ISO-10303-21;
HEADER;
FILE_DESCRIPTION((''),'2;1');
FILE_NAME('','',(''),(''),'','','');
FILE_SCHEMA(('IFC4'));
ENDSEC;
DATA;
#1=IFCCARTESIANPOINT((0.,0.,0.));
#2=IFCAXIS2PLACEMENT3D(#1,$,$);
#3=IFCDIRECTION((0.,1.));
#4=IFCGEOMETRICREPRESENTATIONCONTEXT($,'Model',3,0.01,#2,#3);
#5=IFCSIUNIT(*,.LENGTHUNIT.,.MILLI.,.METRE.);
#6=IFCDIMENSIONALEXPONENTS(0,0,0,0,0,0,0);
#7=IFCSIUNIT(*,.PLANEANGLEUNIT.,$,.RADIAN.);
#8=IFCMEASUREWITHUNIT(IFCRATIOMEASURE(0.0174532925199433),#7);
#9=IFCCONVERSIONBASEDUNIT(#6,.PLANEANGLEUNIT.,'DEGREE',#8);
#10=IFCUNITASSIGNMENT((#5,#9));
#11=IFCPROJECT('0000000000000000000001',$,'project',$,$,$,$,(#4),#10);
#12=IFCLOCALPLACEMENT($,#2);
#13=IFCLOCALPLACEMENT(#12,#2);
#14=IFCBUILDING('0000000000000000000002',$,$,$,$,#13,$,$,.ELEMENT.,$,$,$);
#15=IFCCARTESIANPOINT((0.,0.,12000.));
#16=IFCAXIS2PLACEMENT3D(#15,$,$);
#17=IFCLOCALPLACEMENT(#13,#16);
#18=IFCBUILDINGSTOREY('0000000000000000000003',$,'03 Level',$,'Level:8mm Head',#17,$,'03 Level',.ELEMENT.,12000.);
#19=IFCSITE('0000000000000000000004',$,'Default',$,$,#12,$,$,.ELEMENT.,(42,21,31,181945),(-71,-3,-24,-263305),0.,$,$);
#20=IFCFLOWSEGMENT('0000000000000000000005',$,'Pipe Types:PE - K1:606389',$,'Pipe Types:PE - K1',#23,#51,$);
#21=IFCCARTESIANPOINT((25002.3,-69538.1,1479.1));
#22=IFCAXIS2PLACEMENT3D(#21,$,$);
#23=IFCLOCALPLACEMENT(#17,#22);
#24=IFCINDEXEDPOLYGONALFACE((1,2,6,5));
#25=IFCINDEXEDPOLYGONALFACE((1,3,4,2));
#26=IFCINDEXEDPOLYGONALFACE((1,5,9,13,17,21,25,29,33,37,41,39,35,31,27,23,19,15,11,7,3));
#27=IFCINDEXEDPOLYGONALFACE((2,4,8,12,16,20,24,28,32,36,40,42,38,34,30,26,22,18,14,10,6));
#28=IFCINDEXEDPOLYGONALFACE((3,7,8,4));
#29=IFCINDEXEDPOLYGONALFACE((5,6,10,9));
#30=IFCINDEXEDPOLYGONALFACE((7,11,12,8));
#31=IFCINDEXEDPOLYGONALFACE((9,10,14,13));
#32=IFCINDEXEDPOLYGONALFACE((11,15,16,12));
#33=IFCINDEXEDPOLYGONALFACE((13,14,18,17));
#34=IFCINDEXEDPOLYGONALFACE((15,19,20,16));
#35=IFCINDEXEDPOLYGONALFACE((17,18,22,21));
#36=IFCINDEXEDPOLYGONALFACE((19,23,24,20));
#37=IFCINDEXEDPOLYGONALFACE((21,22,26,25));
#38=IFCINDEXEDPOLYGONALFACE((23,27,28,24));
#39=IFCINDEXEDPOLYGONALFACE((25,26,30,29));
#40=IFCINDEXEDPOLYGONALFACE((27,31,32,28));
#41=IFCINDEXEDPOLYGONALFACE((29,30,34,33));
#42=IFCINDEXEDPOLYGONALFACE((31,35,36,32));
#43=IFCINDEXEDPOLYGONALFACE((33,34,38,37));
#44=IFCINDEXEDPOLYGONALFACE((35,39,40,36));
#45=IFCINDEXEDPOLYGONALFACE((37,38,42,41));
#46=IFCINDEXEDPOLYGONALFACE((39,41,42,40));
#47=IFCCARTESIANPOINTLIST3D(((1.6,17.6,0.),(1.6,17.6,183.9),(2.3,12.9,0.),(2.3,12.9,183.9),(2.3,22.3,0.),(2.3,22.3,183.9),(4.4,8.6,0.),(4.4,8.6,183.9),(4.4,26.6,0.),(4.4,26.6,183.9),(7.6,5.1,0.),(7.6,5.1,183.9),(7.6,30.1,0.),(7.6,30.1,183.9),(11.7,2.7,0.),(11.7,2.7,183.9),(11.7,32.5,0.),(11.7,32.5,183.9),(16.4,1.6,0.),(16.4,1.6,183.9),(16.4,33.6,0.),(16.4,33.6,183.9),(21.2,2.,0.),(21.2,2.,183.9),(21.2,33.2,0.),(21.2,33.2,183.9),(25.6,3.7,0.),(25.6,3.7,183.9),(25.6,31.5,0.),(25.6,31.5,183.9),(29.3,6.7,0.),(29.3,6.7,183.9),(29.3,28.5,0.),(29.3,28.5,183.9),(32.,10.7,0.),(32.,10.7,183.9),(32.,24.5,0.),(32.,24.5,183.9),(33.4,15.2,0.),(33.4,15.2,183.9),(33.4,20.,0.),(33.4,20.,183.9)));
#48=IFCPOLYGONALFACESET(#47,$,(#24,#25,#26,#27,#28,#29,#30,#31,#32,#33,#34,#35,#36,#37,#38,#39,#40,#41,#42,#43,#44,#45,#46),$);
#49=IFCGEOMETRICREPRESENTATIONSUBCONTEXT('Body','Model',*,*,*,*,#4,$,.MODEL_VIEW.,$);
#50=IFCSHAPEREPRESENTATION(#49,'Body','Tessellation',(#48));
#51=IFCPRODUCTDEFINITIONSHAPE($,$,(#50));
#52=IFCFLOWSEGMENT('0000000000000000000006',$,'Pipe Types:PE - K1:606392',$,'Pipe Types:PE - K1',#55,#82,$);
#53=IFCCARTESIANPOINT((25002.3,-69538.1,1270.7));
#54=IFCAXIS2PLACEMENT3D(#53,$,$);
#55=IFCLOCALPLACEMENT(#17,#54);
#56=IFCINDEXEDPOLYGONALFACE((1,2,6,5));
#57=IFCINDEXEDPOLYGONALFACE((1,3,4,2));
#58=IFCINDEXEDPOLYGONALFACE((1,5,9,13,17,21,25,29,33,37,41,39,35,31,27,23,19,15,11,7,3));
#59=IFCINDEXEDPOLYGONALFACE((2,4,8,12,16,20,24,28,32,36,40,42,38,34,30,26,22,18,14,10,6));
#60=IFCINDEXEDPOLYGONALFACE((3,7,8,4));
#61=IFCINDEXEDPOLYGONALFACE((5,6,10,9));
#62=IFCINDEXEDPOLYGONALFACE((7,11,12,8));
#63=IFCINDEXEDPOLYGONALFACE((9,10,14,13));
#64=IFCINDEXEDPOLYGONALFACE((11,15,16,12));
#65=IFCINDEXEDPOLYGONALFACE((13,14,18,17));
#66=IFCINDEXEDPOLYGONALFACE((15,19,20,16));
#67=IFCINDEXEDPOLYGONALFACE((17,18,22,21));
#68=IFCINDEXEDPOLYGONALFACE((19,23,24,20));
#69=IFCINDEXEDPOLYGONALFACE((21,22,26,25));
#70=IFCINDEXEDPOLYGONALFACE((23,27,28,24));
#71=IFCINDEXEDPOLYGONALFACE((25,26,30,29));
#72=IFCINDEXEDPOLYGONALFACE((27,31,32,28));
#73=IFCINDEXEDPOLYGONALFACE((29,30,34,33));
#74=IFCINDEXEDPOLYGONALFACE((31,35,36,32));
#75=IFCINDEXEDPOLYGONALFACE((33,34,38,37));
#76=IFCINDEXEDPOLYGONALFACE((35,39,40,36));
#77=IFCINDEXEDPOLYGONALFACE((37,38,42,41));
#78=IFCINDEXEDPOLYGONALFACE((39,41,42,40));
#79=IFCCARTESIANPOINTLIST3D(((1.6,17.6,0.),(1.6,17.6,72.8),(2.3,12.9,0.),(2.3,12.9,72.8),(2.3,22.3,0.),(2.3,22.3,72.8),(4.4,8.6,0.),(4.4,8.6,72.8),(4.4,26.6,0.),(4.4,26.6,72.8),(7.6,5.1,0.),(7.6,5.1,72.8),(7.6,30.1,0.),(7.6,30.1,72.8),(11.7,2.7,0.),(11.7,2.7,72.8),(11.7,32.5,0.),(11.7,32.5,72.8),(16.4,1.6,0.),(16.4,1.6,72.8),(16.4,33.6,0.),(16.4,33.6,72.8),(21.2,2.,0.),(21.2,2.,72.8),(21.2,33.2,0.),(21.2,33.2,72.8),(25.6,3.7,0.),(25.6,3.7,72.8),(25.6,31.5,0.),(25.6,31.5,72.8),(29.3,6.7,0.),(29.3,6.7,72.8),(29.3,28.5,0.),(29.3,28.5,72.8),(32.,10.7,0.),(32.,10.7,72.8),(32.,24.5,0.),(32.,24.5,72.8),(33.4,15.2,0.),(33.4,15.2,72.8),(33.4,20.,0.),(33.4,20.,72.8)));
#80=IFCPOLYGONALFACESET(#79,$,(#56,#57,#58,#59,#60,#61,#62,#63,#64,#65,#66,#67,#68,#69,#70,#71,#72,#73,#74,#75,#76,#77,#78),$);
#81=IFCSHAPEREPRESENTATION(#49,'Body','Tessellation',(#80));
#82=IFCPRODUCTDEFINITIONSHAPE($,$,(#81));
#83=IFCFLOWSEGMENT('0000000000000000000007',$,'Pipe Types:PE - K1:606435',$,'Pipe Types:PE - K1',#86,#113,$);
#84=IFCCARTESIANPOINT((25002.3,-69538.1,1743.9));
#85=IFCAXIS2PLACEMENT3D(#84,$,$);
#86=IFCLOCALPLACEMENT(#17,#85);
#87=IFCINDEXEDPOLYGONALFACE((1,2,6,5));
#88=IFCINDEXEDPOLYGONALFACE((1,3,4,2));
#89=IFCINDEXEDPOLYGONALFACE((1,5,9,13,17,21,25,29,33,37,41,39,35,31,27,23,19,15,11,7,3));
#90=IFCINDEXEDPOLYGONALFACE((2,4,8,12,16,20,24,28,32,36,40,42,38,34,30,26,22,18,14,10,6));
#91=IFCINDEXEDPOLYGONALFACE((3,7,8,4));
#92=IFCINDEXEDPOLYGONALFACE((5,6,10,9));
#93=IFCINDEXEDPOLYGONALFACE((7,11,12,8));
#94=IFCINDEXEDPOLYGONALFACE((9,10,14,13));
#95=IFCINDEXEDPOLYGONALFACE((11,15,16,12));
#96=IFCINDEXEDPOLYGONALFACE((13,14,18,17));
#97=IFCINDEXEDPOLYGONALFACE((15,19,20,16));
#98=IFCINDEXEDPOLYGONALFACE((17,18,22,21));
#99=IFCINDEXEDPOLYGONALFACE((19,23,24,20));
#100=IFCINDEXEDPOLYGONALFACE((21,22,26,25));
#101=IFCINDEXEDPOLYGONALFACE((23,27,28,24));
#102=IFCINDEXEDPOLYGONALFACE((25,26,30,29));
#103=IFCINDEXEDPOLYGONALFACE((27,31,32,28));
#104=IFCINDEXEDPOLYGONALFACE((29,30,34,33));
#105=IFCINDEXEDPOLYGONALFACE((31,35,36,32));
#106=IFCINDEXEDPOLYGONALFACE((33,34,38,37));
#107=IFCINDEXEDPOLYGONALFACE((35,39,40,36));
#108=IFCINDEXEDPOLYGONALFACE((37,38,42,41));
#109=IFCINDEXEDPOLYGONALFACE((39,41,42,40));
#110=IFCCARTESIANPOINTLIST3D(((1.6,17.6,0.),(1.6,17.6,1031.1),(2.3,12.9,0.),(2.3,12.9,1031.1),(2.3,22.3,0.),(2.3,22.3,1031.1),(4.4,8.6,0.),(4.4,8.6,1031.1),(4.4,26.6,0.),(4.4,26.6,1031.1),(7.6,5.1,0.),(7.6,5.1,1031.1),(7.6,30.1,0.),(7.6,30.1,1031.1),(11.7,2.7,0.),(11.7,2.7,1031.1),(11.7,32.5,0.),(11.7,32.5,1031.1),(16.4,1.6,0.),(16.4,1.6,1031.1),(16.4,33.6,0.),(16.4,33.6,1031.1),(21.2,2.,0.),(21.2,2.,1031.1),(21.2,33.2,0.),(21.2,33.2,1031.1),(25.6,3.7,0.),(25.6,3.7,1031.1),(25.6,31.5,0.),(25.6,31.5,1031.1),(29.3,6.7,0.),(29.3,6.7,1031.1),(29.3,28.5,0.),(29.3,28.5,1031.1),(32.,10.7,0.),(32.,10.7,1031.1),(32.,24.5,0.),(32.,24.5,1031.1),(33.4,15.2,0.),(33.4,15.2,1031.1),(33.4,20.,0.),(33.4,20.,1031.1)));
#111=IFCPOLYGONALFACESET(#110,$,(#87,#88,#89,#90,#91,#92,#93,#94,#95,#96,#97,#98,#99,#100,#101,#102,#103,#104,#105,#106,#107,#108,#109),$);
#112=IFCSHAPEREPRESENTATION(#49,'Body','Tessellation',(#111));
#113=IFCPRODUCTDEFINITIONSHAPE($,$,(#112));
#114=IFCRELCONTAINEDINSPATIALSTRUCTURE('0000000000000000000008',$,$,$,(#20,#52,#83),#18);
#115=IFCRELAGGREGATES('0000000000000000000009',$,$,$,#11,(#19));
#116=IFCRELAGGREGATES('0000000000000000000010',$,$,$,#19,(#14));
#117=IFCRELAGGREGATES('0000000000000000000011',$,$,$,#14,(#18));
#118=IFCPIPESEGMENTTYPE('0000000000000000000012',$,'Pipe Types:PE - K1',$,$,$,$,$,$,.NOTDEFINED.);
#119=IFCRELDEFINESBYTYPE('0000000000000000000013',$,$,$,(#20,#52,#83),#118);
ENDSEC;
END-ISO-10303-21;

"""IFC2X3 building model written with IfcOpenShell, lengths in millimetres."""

from ifc_helpers import new_model, entity, si_unit, converted_unit, direction, frame, origin, origin_2d_with_axis, place, context, subcontext, project, spatial, circle, extrude, type_object, element, save


model = new_model("IFC2X3")

# Units and contexts
model_context = context("Model", 3, precision=0.01, world=origin(), true_north=direction((0.0, 1.0)))
body_context = subcontext(model_context, "Body", "Model", "MODEL_VIEW")
ifc_project = project(units=[si_unit("LENGTHUNIT", "METRE", prefix="MILLI"), converted_unit("PLANEANGLEUNIT", "DEGREE", entity("IfcRatioMeasure", 0.0174532925199433), si_unit("PLANEANGLEUNIT", "RADIAN"), dimensions=[0, 0, 0, 0, 0, 0, 0])], contexts=[model_context])

# Site, building, storey
site_placement = place(None, origin())
site = spatial("IfcSite", under=ifc_project, at=site_placement, Name="Default", CompositionType="ELEMENT", RefLatitude=(42, 21, 31, 181945), RefLongitude=(-71, -3, -24, -263305), RefElevation=0.0)
building_placement = place(site_placement, origin())
building = spatial("IfcBuilding", under=site, at=building_placement, CompositionType="ELEMENT")
storey_placement = place(building_placement, frame((0.0, 0.0, 12000.0)))
storey = spatial("IfcBuildingStorey", under=building, at=storey_placement, Name="03 Level", ObjectType="Level:8mm Head", LongName="03 Level", CompositionType="ELEMENT", Elevation=12000.0)

# Flow segments
pipe_segment_type = type_object("IfcPipeSegmentType", Name="Pipe Types:PE - K1", PredefinedType="NOTDEFINED")
flow_segment_1_placement = place(storey_placement, frame((25002.3, -69538.1, 1479.1)))
element("IfcFlowSegment", 1, at=flow_segment_1_placement, inside=storey, type_object=pipe_segment_type, Name="Pipe Types:PE - K1:606389", ObjectType="Pipe Types:PE - K1", context=body_context, shape_type="SweptSolid", body=[
    extrude(circle(Radius=16.0, at=origin_2d_with_axis()), frame((17.6, 17.6, 0.0), z_axis=(0.0, 0.0, 1.0), x_axis=(-1.0, 0.0, 0.0)), (0.0, 0.0, 1.0), 183.9),
])
flow_segment_2_placement = place(storey_placement, frame((25002.3, -69538.1, 1270.7)))
element("IfcFlowSegment", 2, at=flow_segment_2_placement, inside=storey, type_object=pipe_segment_type, Name="Pipe Types:PE - K1:606392", ObjectType="Pipe Types:PE - K1", context=body_context, shape_type="SweptSolid", body=[
    extrude(circle(Radius=16.0, at=origin_2d_with_axis()), frame((17.6, 17.6, 0.0), z_axis=(0.0, 0.0, 1.0), x_axis=(-1.0, 0.0, 0.0)), (0.0, 0.0, 1.0), 72.8),
])
flow_segment_3_placement = place(storey_placement, frame((25002.3, -69538.1, 1743.9)))
element("IfcFlowSegment", 3, at=flow_segment_3_placement, inside=storey, type_object=pipe_segment_type, Name="Pipe Types:PE - K1:606435", ObjectType="Pipe Types:PE - K1", context=body_context, shape_type="SweptSolid", body=[
    extrude(circle(Radius=16.0, at=origin_2d_with_axis()), frame((17.6, 17.6, 0.0), z_axis=(0.0, 0.0, 1.0), x_axis=(-1.0, 0.0, 0.0)), (0.0, 0.0, 1.0), 1031.1),
])

save(model, "model.ifc")
